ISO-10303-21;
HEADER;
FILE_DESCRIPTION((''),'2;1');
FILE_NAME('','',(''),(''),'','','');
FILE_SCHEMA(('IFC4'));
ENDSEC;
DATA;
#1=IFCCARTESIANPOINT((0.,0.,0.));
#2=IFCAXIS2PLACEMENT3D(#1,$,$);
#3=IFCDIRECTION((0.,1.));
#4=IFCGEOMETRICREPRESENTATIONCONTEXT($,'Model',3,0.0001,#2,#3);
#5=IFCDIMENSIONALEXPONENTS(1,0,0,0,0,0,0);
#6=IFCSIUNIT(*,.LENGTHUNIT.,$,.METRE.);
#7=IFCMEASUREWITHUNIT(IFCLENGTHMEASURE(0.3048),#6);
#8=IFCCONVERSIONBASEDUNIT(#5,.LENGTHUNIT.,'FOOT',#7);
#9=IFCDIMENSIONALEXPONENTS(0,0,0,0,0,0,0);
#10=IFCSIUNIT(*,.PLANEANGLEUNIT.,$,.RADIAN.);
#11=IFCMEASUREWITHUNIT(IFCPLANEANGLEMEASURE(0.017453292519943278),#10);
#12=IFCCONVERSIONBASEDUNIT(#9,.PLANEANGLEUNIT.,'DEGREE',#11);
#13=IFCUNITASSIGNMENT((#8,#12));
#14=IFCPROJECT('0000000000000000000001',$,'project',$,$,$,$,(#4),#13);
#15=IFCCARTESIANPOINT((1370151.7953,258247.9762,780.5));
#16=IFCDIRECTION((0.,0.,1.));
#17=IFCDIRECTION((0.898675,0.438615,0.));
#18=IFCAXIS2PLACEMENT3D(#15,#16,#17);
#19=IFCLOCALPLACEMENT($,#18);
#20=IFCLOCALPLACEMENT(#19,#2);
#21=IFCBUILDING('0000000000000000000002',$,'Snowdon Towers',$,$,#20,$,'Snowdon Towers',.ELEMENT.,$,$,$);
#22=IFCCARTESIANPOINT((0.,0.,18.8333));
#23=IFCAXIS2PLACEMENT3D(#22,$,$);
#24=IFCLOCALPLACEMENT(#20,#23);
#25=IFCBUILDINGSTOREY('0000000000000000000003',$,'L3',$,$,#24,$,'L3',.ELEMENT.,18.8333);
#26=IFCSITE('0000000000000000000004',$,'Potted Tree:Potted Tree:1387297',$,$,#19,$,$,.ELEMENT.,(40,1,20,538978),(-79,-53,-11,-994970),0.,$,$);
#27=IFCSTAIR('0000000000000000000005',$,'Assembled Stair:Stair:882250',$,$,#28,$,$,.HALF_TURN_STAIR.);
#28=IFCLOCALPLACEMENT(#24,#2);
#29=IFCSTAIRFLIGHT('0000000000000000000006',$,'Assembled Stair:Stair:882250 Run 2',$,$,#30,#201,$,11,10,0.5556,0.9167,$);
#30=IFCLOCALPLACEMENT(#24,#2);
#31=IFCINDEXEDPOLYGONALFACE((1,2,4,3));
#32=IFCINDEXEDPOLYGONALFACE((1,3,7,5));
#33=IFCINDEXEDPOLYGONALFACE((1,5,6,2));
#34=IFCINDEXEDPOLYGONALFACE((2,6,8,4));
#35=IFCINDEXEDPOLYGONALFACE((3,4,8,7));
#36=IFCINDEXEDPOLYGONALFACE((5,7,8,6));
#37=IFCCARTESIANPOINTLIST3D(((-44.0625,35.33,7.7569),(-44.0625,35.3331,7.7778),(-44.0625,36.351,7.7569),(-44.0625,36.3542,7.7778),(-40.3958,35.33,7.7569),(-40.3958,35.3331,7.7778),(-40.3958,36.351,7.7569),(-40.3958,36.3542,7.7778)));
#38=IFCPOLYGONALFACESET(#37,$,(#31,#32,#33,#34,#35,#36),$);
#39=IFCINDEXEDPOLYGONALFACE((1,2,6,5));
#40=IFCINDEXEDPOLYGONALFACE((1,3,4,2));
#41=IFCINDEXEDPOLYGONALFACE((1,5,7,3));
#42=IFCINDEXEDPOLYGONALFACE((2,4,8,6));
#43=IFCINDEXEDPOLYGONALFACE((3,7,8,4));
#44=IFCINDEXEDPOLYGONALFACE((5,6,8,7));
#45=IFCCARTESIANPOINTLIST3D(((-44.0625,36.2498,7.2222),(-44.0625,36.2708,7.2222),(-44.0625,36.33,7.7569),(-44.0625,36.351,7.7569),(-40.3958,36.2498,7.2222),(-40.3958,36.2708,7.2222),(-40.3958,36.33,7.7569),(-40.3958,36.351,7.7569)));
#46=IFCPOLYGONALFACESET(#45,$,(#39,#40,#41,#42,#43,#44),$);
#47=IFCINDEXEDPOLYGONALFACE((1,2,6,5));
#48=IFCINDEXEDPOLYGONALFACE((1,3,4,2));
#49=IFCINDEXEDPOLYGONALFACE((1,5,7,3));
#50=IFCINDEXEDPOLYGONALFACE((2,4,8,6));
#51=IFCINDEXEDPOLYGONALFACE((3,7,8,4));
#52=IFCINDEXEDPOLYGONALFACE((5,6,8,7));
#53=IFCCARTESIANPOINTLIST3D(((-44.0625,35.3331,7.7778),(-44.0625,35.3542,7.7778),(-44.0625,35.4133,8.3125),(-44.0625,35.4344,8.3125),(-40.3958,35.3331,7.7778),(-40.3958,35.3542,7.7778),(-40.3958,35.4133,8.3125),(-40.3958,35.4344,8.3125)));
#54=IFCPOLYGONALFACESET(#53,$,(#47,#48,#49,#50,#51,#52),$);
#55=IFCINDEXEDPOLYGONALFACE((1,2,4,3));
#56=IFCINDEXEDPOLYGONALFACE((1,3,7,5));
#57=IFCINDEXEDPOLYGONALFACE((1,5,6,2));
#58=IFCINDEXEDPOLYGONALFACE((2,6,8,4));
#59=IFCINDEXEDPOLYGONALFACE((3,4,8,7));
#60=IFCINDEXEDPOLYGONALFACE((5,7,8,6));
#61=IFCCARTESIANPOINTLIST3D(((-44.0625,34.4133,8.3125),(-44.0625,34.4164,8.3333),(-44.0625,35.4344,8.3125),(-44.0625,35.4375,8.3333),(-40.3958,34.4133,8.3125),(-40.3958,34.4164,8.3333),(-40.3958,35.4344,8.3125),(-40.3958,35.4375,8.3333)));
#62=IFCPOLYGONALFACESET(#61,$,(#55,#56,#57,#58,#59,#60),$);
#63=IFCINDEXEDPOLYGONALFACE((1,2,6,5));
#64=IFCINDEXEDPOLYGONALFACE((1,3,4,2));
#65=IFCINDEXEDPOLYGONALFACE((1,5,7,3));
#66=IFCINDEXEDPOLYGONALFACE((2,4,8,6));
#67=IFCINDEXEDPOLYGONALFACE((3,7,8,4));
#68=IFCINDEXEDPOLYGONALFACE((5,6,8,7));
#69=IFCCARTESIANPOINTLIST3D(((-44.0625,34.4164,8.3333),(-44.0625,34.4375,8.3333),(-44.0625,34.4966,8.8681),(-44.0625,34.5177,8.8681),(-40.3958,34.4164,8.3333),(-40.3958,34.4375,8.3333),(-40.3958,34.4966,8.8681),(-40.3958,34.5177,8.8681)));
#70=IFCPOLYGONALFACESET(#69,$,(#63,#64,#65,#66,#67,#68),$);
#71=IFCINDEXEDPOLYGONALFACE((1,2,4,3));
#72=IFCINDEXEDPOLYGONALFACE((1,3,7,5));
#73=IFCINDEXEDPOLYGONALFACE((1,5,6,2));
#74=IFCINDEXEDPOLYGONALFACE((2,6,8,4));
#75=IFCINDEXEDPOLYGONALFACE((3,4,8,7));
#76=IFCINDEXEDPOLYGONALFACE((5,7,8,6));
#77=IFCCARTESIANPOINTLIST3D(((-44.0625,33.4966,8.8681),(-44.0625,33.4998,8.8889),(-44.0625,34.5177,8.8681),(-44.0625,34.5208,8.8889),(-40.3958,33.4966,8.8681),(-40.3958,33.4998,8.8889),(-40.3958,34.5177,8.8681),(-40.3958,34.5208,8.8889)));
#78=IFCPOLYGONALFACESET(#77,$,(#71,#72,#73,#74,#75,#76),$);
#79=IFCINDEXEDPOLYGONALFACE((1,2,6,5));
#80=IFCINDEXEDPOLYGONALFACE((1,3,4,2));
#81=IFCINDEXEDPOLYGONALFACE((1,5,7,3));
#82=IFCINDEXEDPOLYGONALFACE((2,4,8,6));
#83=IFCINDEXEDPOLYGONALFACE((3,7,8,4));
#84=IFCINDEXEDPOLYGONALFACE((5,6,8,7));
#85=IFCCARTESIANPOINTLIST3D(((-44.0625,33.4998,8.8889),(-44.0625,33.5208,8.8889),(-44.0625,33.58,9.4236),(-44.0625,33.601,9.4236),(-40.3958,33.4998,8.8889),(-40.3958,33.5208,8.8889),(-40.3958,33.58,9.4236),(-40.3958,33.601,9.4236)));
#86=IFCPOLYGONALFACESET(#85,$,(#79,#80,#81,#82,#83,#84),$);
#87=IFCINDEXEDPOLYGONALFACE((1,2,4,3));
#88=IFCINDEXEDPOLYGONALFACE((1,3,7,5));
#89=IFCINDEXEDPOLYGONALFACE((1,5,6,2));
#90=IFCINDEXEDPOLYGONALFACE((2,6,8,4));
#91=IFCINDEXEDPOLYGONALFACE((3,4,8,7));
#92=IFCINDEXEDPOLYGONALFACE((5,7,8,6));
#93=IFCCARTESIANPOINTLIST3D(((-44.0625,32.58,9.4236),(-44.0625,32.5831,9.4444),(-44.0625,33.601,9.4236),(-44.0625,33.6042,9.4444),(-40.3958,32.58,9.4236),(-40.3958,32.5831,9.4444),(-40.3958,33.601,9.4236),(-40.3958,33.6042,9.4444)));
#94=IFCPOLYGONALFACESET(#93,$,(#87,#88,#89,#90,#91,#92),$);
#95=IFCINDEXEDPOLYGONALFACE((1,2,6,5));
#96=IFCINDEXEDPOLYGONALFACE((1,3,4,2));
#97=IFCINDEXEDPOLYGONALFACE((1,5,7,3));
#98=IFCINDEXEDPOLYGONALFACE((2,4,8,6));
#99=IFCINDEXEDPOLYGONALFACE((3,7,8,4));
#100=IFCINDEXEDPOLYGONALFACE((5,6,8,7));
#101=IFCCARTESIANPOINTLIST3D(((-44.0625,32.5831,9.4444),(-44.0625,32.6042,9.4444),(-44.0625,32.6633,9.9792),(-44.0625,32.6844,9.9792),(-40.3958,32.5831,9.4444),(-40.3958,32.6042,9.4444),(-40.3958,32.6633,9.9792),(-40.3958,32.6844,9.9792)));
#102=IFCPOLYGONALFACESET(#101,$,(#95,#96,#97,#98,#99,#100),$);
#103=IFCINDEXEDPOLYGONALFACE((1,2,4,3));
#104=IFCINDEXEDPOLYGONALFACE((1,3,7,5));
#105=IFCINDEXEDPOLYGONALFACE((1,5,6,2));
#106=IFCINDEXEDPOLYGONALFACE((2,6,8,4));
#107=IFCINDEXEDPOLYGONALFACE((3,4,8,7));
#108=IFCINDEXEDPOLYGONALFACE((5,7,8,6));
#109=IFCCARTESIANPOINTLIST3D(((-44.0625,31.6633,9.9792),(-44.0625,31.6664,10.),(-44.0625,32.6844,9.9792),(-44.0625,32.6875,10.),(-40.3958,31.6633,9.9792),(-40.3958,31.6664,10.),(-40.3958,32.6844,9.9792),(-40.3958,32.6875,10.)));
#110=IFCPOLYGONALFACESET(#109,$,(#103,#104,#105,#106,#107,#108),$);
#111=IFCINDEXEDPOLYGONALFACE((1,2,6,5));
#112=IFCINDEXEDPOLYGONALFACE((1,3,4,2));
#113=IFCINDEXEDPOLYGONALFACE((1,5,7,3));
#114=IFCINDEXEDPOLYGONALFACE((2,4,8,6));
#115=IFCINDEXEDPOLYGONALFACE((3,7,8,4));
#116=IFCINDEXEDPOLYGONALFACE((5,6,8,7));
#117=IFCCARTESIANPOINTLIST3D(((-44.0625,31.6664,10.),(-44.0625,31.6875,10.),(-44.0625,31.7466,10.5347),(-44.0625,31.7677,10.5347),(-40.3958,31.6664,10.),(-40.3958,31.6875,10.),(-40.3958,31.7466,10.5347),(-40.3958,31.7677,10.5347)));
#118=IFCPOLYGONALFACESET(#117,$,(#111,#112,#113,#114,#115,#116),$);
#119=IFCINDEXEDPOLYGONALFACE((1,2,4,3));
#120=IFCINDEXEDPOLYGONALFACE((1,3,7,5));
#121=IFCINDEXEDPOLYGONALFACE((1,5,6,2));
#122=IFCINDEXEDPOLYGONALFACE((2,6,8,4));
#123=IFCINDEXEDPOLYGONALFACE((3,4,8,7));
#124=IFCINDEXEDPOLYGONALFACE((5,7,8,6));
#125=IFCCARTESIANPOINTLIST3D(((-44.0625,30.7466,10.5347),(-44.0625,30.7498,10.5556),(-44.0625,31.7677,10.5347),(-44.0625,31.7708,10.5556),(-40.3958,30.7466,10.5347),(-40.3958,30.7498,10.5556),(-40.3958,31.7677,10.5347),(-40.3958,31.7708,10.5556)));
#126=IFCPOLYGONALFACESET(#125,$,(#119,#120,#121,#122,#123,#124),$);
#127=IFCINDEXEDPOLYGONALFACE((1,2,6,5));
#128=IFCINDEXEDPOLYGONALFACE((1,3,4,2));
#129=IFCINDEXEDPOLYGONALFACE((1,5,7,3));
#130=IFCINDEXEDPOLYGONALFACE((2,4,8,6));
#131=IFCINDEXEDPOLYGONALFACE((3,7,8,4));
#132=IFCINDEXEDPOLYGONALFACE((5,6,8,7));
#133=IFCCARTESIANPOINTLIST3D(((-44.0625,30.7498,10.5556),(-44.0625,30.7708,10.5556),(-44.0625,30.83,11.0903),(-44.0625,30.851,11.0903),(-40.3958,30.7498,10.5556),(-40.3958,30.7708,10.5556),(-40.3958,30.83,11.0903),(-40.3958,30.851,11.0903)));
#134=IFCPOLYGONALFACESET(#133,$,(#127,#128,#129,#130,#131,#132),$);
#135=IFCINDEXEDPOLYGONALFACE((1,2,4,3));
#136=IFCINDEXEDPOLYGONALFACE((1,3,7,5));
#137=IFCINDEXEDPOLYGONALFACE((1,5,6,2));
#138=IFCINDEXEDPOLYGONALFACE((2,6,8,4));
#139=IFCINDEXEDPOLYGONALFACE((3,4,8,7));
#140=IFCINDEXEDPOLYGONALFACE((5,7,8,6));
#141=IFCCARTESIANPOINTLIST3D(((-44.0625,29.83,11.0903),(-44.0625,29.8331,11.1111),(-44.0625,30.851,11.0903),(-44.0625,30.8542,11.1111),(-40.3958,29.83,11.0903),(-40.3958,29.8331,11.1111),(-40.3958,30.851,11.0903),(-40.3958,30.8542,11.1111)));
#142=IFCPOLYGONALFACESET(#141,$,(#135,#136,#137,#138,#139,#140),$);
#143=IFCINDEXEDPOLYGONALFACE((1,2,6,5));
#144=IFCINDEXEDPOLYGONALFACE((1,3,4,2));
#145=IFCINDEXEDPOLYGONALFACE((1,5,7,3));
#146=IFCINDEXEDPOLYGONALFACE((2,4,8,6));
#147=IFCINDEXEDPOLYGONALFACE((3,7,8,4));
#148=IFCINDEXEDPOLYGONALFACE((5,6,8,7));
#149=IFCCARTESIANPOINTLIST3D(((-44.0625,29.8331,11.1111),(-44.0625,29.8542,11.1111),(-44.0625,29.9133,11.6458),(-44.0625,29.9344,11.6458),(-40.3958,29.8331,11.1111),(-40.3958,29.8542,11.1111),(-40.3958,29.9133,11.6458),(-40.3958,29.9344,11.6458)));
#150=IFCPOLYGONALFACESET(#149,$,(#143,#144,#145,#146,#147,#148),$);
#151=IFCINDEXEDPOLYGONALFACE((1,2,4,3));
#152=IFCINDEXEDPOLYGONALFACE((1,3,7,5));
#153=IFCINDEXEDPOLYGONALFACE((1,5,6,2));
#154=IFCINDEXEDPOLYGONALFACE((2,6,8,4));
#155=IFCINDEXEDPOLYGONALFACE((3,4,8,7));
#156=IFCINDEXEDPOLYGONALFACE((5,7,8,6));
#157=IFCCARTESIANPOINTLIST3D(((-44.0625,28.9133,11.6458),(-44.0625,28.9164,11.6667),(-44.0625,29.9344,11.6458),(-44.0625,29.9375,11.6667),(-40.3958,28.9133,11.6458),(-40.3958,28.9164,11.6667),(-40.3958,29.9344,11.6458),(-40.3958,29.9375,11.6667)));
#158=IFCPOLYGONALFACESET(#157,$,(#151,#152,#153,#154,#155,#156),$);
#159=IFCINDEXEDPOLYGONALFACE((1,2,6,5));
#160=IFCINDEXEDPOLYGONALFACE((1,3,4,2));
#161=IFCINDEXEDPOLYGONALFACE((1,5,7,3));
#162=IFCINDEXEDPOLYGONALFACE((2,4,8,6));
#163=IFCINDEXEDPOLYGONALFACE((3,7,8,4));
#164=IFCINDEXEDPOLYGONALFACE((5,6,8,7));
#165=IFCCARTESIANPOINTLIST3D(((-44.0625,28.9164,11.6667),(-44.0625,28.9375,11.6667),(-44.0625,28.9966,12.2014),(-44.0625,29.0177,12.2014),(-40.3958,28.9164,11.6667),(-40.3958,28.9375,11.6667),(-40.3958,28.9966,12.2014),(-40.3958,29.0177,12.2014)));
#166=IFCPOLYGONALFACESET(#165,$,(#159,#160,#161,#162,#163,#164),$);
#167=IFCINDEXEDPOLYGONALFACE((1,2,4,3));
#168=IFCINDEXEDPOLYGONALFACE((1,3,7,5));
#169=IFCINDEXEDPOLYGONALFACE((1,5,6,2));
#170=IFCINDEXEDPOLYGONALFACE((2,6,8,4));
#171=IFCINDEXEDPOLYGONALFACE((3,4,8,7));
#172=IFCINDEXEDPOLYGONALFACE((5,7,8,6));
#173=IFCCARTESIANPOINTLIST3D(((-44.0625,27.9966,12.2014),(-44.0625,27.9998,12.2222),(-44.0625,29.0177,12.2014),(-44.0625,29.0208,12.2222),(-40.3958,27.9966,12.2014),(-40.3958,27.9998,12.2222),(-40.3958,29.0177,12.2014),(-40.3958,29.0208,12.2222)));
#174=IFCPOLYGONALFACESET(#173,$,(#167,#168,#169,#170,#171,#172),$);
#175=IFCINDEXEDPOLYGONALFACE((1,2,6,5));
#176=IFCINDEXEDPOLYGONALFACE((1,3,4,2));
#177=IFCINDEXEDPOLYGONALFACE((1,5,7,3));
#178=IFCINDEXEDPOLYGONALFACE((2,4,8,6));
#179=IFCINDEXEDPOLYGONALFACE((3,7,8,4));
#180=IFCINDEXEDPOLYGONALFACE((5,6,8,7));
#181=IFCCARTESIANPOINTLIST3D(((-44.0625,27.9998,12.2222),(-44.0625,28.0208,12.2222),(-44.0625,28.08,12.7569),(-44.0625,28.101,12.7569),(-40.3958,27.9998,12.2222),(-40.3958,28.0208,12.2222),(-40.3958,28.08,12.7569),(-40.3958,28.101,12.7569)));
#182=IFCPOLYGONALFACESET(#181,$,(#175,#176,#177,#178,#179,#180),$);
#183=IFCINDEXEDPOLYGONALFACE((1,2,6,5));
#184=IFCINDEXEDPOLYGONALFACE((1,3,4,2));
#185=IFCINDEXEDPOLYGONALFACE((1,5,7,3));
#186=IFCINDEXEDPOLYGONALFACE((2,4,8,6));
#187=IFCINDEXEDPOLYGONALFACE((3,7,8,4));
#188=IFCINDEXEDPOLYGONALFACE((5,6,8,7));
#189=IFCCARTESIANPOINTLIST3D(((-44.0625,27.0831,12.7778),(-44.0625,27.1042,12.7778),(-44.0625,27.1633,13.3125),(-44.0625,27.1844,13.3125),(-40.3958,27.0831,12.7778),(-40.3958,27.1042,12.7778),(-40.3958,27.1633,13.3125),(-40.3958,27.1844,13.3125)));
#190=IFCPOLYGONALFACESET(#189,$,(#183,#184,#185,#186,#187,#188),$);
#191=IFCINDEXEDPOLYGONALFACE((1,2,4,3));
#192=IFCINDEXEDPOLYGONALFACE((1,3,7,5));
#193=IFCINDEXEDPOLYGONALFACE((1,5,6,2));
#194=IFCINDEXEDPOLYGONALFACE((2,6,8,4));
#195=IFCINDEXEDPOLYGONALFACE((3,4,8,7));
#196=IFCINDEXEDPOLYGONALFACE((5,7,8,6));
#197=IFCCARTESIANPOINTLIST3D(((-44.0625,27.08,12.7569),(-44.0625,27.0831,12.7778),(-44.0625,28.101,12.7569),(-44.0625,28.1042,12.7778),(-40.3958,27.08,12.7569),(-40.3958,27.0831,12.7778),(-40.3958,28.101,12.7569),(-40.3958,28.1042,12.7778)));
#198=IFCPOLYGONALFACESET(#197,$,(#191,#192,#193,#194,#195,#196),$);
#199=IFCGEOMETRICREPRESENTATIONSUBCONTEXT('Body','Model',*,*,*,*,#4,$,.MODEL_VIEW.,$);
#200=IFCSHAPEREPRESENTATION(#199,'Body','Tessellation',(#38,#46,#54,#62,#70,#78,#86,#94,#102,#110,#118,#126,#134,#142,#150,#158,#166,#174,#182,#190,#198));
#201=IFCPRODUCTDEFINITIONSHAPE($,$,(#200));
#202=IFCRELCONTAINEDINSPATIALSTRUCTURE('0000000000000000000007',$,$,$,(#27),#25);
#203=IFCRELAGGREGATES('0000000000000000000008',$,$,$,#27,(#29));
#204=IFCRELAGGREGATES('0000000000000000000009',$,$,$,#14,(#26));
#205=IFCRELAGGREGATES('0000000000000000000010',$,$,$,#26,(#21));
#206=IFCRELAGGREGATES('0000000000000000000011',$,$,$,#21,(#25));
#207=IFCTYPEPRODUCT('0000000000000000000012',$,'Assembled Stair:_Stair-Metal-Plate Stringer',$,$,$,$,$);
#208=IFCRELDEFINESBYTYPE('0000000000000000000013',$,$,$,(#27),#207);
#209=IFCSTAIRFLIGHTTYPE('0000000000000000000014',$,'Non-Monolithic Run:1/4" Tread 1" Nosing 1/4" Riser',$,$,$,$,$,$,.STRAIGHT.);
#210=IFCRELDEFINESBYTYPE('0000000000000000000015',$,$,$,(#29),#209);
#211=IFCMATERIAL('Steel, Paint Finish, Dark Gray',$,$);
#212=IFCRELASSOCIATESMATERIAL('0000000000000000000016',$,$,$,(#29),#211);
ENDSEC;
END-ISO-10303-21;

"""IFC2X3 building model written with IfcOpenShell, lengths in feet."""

from ifc_helpers import new_model, entity, si_unit, converted_unit, direction, frame, origin, place, context, subcontext, project, spatial, polyline, outline, extrude, material, type_object, element, aggregate, save


model = new_model("IFC2X3")

# Units and contexts
model_context = context("Model", 3, precision=0.0001, world=origin(), true_north=direction((0.0, 1.0)))
body_context = subcontext(model_context, "Body", "Model", "MODEL_VIEW")
ifc_project = project(units=[converted_unit("LENGTHUNIT", "FOOT", entity("IfcLengthMeasure", 0.3048), si_unit("LENGTHUNIT", "METRE"), dimensions=[1, 0, 0, 0, 0, 0, 0]), converted_unit("PLANEANGLEUNIT", "DEGREE", entity("IfcPlaneAngleMeasure", 0.017453292519943278), si_unit("PLANEANGLEUNIT", "RADIAN"), dimensions=[0, 0, 0, 0, 0, 0, 0])], contexts=[model_context])

# Site, building, storey
site_placement = place(None, frame((1370151.7953, 258247.9762, 780.5), z_axis=(0.0, 0.0, 1.0), x_axis=(0.898675, 0.438615, 0.0)))
site = spatial("IfcSite", under=ifc_project, at=site_placement, Name="Potted Tree:Potted Tree:1387297", CompositionType="ELEMENT", RefLatitude=(40, 1, 20, 538978), RefLongitude=(-79, -53, -11, -994970), RefElevation=0.0)
building_placement = place(site_placement, origin())
building = spatial("IfcBuilding", under=site, at=building_placement, Name="Snowdon Towers", LongName="Snowdon Towers", CompositionType="ELEMENT")
storey_placement = place(building_placement, frame((0.0, 0.0, 18.8333)))
storey = spatial("IfcBuildingStorey", under=building, at=storey_placement, Name="L3", LongName="L3", CompositionType="ELEMENT", Elevation=18.8333)

# Stair
type_product = type_object("IfcTypeProduct", Name="Assembled Stair:_Stair-Metal-Plate Stringer")
ifc_material_1 = material(Name="Steel, Paint Finish, Dark Gray")
stair_1_placement = place(storey_placement, origin())
stair_1 = element("IfcStair", 1, at=stair_1_placement, inside=storey, type_object=type_product, Name="Assembled Stair:Stair:882250", ShapeType="HALF_TURN_STAIR")

# Stair flight
stair_flight_type = type_object("IfcStairFlightType", Name="Non-Monolithic Run:1/4\" Tread 1\" Nosing 1/4\" Riser", PredefinedType="STRAIGHT")
stair_flight_1_placement = place(stair_1_placement, origin())
stair_flight_1 = element("IfcStairFlight", 2, at=stair_flight_1_placement, type_object=stair_flight_type, material=ifc_material_1, Name="Assembled Stair:Stair:882250 Run 2", NumberOfRiser=11, NumberOfTreads=10, RiserHeight=0.5556, TreadLength=0.9167, context=body_context, shape_type="SweptSolid", body=[
    extrude(outline(polyline([(0.0652, -0.5049), (0.0863, -0.5049), (-0.0652, 0.5049), (-0.0863, 0.5049), (0.0652, -0.5049)])), frame((-44.0625, 35.8421, 7.7674), z_axis=(1.0, 0.0, 0.0), x_axis=(0.0, -0.14834, -0.988936)), (0.0, 0.0, 1.0), 3.6667),
    extrude(outline(polyline([(-0.0506, -0.2674), (-0.0296, -0.2674), (0.0506, 0.2674), (0.0296, 0.2674), (-0.0506, -0.2674)])), frame((-44.0625, 36.3004, 7.4896), z_axis=(1.0, 0.0, 0.0), x_axis=(0.0, -1.0, 0.0)), (0.0, 0.0, 1.0), 3.6667),
    extrude(outline(polyline([(-0.0506, -0.2674), (-0.0296, -0.2674), (0.0506, 0.2674), (0.0296, 0.2674), (-0.0506, -0.2674)])), frame((-44.0625, 35.3837, 8.0451), z_axis=(1.0, 0.0, 0.0), x_axis=(0.0, -1.0, 0.0)), (0.0, 0.0, 1.0), 3.6667),
    extrude(outline(polyline([(0.0652, -0.5049), (0.0863, -0.5049), (-0.0652, 0.5049), (-0.0863, 0.5049), (0.0652, -0.5049)])), frame((-44.0625, 34.9254, 8.3229), z_axis=(1.0, 0.0, 0.0), x_axis=(0.0, -0.14834, -0.988936)), (0.0, 0.0, 1.0), 3.6667),
    extrude(outline(polyline([(-0.0506, -0.2674), (-0.0296, -0.2674), (0.0506, 0.2674), (0.0296, 0.2674), (-0.0506, -0.2674)])), frame((-44.0625, 34.4671, 8.6007), z_axis=(1.0, 0.0, 0.0), x_axis=(0.0, -1.0, 0.0)), (0.0, 0.0, 1.0), 3.6667),
    extrude(outline(polyline([(0.0652, -0.5049), (0.0863, -0.5049), (-0.0652, 0.5049), (-0.0863, 0.5049), (0.0652, -0.5049)])), frame((-44.0625, 34.0087, 8.8785), z_axis=(1.0, 0.0, 0.0), x_axis=(0.0, -0.14834, -0.988936)), (0.0, 0.0, 1.0), 3.6667),
    extrude(outline(polyline([(-0.0506, -0.2674), (-0.0296, -0.2674), (0.0506, 0.2674), (0.0296, 0.2674), (-0.0506, -0.2674)])), frame((-44.0625, 33.5504, 9.1562), z_axis=(1.0, 0.0, 0.0), x_axis=(0.0, -1.0, 0.0)), (0.0, 0.0, 1.0), 3.6667),
    extrude(outline(polyline([(0.0652, -0.5049), (0.0863, -0.5049), (-0.0652, 0.5049), (-0.0863, 0.5049), (0.0652, -0.5049)])), frame((-44.0625, 33.0921, 9.434), z_axis=(1.0, 0.0, 0.0), x_axis=(0.0, -0.14834, -0.988936)), (0.0, 0.0, 1.0), 3.6667),
    extrude(outline(polyline([(-0.0506, -0.2674), (-0.0296, -0.2674), (0.0506, 0.2674), (0.0296, 0.2674), (-0.0506, -0.2674)])), frame((-44.0625, 32.6337, 9.7118), z_axis=(1.0, 0.0, 0.0), x_axis=(0.0, -1.0, 0.0)), (0.0, 0.0, 1.0), 3.6667),
    extrude(outline(polyline([(0.0652, -0.5049), (0.0863, -0.5049), (-0.0652, 0.5049), (-0.0863, 0.5049), (0.0652, -0.5049)])), frame((-44.0625, 32.1754, 9.9896), z_axis=(1.0, 0.0, 0.0), x_axis=(0.0, -0.14834, -0.988936)), (0.0, 0.0, 1.0), 3.6667),
    extrude(outline(polyline([(-0.0506, -0.2674), (-0.0296, -0.2674), (0.0506, 0.2674), (0.0296, 0.2674), (-0.0506, -0.2674)])), frame((-44.0625, 31.7171, 10.2674), z_axis=(1.0, 0.0, 0.0), x_axis=(0.0, -1.0, 0.0)), (0.0, 0.0, 1.0), 3.6667),
    extrude(outline(polyline([(0.0652, -0.5049), (0.0863, -0.5049), (-0.0652, 0.5049), (-0.0863, 0.5049), (0.0652, -0.5049)])), frame((-44.0625, 31.2587, 10.5451), z_axis=(1.0, 0.0, 0.0), x_axis=(0.0, -0.14834, -0.988936)), (0.0, 0.0, 1.0), 3.6667),
    extrude(outline(polyline([(-0.0506, -0.2674), (-0.0296, -0.2674), (0.0506, 0.2674), (0.0296, 0.2674), (-0.0506, -0.2674)])), frame((-44.0625, 30.8004, 10.8229), z_axis=(1.0, 0.0, 0.0), x_axis=(0.0, -1.0, 0.0)), (0.0, 0.0, 1.0), 3.6667),
    extrude(outline(polyline([(0.0652, -0.5049), (0.0863, -0.5049), (-0.0652, 0.5049), (-0.0863, 0.5049), (0.0652, -0.5049)])), frame((-44.0625, 30.3421, 11.1007), z_axis=(1.0, 0.0, 0.0), x_axis=(0.0, -0.14834, -0.988936)), (0.0, 0.0, 1.0), 3.6667),
    extrude(outline(polyline([(-0.0506, -0.2674), (-0.0296, -0.2674), (0.0506, 0.2674), (0.0296, 0.2674), (-0.0506, -0.2674)])), frame((-44.0625, 29.8837, 11.3785), z_axis=(1.0, 0.0, 0.0), x_axis=(0.0, -1.0, 0.0)), (0.0, 0.0, 1.0), 3.6667),
    extrude(outline(polyline([(0.0652, -0.5049), (0.0863, -0.5049), (-0.0652, 0.5049), (-0.0863, 0.5049), (0.0652, -0.5049)])), frame((-44.0625, 29.4254, 11.6563), z_axis=(1.0, 0.0, 0.0), x_axis=(0.0, -0.14834, -0.988936)), (0.0, 0.0, 1.0), 3.6667),
    extrude(outline(polyline([(-0.0506, -0.2674), (-0.0296, -0.2674), (0.0506, 0.2674), (0.0296, 0.2674), (-0.0506, -0.2674)])), frame((-44.0625, 28.9671, 11.934), z_axis=(1.0, 0.0, 0.0), x_axis=(0.0, -1.0, 0.0)), (0.0, 0.0, 1.0), 3.6667),
    extrude(outline(polyline([(0.0652, -0.5049), (0.0863, -0.5049), (-0.0652, 0.5049), (-0.0863, 0.5049), (0.0652, -0.5049)])), frame((-44.0625, 28.5087, 12.2118), z_axis=(1.0, 0.0, 0.0), x_axis=(0.0, -0.14834, -0.988936)), (0.0, 0.0, 1.0), 3.6667),
    extrude(outline(polyline([(-0.0506, -0.2674), (-0.0296, -0.2674), (0.0506, 0.2674), (0.0296, 0.2674), (-0.0506, -0.2674)])), frame((-44.0625, 28.0504, 12.4896), z_axis=(1.0, 0.0, 0.0), x_axis=(0.0, -1.0, 0.0)), (0.0, 0.0, 1.0), 3.6667),
    extrude(outline(polyline([(-0.0506, -0.2674), (-0.0296, -0.2674), (0.0506, 0.2674), (0.0296, 0.2674), (-0.0506, -0.2674)])), frame((-44.0625, 27.1337, 13.0451), z_axis=(1.0, 0.0, 0.0), x_axis=(0.0, -1.0, 0.0)), (0.0, 0.0, 1.0), 3.6667),
    extrude(outline(polyline([(0.0652, -0.5049), (0.0863, -0.5049), (-0.0652, 0.5049), (-0.0863, 0.5049), (0.0652, -0.5049)])), frame((-44.0625, 27.5921, 12.7674), z_axis=(1.0, 0.0, 0.0), x_axis=(0.0, -0.14834, -0.988936)), (0.0, 0.0, 1.0), 3.6667),
])
aggregate(stair_1, [stair_flight_1])

save(model, "model.ifc")
